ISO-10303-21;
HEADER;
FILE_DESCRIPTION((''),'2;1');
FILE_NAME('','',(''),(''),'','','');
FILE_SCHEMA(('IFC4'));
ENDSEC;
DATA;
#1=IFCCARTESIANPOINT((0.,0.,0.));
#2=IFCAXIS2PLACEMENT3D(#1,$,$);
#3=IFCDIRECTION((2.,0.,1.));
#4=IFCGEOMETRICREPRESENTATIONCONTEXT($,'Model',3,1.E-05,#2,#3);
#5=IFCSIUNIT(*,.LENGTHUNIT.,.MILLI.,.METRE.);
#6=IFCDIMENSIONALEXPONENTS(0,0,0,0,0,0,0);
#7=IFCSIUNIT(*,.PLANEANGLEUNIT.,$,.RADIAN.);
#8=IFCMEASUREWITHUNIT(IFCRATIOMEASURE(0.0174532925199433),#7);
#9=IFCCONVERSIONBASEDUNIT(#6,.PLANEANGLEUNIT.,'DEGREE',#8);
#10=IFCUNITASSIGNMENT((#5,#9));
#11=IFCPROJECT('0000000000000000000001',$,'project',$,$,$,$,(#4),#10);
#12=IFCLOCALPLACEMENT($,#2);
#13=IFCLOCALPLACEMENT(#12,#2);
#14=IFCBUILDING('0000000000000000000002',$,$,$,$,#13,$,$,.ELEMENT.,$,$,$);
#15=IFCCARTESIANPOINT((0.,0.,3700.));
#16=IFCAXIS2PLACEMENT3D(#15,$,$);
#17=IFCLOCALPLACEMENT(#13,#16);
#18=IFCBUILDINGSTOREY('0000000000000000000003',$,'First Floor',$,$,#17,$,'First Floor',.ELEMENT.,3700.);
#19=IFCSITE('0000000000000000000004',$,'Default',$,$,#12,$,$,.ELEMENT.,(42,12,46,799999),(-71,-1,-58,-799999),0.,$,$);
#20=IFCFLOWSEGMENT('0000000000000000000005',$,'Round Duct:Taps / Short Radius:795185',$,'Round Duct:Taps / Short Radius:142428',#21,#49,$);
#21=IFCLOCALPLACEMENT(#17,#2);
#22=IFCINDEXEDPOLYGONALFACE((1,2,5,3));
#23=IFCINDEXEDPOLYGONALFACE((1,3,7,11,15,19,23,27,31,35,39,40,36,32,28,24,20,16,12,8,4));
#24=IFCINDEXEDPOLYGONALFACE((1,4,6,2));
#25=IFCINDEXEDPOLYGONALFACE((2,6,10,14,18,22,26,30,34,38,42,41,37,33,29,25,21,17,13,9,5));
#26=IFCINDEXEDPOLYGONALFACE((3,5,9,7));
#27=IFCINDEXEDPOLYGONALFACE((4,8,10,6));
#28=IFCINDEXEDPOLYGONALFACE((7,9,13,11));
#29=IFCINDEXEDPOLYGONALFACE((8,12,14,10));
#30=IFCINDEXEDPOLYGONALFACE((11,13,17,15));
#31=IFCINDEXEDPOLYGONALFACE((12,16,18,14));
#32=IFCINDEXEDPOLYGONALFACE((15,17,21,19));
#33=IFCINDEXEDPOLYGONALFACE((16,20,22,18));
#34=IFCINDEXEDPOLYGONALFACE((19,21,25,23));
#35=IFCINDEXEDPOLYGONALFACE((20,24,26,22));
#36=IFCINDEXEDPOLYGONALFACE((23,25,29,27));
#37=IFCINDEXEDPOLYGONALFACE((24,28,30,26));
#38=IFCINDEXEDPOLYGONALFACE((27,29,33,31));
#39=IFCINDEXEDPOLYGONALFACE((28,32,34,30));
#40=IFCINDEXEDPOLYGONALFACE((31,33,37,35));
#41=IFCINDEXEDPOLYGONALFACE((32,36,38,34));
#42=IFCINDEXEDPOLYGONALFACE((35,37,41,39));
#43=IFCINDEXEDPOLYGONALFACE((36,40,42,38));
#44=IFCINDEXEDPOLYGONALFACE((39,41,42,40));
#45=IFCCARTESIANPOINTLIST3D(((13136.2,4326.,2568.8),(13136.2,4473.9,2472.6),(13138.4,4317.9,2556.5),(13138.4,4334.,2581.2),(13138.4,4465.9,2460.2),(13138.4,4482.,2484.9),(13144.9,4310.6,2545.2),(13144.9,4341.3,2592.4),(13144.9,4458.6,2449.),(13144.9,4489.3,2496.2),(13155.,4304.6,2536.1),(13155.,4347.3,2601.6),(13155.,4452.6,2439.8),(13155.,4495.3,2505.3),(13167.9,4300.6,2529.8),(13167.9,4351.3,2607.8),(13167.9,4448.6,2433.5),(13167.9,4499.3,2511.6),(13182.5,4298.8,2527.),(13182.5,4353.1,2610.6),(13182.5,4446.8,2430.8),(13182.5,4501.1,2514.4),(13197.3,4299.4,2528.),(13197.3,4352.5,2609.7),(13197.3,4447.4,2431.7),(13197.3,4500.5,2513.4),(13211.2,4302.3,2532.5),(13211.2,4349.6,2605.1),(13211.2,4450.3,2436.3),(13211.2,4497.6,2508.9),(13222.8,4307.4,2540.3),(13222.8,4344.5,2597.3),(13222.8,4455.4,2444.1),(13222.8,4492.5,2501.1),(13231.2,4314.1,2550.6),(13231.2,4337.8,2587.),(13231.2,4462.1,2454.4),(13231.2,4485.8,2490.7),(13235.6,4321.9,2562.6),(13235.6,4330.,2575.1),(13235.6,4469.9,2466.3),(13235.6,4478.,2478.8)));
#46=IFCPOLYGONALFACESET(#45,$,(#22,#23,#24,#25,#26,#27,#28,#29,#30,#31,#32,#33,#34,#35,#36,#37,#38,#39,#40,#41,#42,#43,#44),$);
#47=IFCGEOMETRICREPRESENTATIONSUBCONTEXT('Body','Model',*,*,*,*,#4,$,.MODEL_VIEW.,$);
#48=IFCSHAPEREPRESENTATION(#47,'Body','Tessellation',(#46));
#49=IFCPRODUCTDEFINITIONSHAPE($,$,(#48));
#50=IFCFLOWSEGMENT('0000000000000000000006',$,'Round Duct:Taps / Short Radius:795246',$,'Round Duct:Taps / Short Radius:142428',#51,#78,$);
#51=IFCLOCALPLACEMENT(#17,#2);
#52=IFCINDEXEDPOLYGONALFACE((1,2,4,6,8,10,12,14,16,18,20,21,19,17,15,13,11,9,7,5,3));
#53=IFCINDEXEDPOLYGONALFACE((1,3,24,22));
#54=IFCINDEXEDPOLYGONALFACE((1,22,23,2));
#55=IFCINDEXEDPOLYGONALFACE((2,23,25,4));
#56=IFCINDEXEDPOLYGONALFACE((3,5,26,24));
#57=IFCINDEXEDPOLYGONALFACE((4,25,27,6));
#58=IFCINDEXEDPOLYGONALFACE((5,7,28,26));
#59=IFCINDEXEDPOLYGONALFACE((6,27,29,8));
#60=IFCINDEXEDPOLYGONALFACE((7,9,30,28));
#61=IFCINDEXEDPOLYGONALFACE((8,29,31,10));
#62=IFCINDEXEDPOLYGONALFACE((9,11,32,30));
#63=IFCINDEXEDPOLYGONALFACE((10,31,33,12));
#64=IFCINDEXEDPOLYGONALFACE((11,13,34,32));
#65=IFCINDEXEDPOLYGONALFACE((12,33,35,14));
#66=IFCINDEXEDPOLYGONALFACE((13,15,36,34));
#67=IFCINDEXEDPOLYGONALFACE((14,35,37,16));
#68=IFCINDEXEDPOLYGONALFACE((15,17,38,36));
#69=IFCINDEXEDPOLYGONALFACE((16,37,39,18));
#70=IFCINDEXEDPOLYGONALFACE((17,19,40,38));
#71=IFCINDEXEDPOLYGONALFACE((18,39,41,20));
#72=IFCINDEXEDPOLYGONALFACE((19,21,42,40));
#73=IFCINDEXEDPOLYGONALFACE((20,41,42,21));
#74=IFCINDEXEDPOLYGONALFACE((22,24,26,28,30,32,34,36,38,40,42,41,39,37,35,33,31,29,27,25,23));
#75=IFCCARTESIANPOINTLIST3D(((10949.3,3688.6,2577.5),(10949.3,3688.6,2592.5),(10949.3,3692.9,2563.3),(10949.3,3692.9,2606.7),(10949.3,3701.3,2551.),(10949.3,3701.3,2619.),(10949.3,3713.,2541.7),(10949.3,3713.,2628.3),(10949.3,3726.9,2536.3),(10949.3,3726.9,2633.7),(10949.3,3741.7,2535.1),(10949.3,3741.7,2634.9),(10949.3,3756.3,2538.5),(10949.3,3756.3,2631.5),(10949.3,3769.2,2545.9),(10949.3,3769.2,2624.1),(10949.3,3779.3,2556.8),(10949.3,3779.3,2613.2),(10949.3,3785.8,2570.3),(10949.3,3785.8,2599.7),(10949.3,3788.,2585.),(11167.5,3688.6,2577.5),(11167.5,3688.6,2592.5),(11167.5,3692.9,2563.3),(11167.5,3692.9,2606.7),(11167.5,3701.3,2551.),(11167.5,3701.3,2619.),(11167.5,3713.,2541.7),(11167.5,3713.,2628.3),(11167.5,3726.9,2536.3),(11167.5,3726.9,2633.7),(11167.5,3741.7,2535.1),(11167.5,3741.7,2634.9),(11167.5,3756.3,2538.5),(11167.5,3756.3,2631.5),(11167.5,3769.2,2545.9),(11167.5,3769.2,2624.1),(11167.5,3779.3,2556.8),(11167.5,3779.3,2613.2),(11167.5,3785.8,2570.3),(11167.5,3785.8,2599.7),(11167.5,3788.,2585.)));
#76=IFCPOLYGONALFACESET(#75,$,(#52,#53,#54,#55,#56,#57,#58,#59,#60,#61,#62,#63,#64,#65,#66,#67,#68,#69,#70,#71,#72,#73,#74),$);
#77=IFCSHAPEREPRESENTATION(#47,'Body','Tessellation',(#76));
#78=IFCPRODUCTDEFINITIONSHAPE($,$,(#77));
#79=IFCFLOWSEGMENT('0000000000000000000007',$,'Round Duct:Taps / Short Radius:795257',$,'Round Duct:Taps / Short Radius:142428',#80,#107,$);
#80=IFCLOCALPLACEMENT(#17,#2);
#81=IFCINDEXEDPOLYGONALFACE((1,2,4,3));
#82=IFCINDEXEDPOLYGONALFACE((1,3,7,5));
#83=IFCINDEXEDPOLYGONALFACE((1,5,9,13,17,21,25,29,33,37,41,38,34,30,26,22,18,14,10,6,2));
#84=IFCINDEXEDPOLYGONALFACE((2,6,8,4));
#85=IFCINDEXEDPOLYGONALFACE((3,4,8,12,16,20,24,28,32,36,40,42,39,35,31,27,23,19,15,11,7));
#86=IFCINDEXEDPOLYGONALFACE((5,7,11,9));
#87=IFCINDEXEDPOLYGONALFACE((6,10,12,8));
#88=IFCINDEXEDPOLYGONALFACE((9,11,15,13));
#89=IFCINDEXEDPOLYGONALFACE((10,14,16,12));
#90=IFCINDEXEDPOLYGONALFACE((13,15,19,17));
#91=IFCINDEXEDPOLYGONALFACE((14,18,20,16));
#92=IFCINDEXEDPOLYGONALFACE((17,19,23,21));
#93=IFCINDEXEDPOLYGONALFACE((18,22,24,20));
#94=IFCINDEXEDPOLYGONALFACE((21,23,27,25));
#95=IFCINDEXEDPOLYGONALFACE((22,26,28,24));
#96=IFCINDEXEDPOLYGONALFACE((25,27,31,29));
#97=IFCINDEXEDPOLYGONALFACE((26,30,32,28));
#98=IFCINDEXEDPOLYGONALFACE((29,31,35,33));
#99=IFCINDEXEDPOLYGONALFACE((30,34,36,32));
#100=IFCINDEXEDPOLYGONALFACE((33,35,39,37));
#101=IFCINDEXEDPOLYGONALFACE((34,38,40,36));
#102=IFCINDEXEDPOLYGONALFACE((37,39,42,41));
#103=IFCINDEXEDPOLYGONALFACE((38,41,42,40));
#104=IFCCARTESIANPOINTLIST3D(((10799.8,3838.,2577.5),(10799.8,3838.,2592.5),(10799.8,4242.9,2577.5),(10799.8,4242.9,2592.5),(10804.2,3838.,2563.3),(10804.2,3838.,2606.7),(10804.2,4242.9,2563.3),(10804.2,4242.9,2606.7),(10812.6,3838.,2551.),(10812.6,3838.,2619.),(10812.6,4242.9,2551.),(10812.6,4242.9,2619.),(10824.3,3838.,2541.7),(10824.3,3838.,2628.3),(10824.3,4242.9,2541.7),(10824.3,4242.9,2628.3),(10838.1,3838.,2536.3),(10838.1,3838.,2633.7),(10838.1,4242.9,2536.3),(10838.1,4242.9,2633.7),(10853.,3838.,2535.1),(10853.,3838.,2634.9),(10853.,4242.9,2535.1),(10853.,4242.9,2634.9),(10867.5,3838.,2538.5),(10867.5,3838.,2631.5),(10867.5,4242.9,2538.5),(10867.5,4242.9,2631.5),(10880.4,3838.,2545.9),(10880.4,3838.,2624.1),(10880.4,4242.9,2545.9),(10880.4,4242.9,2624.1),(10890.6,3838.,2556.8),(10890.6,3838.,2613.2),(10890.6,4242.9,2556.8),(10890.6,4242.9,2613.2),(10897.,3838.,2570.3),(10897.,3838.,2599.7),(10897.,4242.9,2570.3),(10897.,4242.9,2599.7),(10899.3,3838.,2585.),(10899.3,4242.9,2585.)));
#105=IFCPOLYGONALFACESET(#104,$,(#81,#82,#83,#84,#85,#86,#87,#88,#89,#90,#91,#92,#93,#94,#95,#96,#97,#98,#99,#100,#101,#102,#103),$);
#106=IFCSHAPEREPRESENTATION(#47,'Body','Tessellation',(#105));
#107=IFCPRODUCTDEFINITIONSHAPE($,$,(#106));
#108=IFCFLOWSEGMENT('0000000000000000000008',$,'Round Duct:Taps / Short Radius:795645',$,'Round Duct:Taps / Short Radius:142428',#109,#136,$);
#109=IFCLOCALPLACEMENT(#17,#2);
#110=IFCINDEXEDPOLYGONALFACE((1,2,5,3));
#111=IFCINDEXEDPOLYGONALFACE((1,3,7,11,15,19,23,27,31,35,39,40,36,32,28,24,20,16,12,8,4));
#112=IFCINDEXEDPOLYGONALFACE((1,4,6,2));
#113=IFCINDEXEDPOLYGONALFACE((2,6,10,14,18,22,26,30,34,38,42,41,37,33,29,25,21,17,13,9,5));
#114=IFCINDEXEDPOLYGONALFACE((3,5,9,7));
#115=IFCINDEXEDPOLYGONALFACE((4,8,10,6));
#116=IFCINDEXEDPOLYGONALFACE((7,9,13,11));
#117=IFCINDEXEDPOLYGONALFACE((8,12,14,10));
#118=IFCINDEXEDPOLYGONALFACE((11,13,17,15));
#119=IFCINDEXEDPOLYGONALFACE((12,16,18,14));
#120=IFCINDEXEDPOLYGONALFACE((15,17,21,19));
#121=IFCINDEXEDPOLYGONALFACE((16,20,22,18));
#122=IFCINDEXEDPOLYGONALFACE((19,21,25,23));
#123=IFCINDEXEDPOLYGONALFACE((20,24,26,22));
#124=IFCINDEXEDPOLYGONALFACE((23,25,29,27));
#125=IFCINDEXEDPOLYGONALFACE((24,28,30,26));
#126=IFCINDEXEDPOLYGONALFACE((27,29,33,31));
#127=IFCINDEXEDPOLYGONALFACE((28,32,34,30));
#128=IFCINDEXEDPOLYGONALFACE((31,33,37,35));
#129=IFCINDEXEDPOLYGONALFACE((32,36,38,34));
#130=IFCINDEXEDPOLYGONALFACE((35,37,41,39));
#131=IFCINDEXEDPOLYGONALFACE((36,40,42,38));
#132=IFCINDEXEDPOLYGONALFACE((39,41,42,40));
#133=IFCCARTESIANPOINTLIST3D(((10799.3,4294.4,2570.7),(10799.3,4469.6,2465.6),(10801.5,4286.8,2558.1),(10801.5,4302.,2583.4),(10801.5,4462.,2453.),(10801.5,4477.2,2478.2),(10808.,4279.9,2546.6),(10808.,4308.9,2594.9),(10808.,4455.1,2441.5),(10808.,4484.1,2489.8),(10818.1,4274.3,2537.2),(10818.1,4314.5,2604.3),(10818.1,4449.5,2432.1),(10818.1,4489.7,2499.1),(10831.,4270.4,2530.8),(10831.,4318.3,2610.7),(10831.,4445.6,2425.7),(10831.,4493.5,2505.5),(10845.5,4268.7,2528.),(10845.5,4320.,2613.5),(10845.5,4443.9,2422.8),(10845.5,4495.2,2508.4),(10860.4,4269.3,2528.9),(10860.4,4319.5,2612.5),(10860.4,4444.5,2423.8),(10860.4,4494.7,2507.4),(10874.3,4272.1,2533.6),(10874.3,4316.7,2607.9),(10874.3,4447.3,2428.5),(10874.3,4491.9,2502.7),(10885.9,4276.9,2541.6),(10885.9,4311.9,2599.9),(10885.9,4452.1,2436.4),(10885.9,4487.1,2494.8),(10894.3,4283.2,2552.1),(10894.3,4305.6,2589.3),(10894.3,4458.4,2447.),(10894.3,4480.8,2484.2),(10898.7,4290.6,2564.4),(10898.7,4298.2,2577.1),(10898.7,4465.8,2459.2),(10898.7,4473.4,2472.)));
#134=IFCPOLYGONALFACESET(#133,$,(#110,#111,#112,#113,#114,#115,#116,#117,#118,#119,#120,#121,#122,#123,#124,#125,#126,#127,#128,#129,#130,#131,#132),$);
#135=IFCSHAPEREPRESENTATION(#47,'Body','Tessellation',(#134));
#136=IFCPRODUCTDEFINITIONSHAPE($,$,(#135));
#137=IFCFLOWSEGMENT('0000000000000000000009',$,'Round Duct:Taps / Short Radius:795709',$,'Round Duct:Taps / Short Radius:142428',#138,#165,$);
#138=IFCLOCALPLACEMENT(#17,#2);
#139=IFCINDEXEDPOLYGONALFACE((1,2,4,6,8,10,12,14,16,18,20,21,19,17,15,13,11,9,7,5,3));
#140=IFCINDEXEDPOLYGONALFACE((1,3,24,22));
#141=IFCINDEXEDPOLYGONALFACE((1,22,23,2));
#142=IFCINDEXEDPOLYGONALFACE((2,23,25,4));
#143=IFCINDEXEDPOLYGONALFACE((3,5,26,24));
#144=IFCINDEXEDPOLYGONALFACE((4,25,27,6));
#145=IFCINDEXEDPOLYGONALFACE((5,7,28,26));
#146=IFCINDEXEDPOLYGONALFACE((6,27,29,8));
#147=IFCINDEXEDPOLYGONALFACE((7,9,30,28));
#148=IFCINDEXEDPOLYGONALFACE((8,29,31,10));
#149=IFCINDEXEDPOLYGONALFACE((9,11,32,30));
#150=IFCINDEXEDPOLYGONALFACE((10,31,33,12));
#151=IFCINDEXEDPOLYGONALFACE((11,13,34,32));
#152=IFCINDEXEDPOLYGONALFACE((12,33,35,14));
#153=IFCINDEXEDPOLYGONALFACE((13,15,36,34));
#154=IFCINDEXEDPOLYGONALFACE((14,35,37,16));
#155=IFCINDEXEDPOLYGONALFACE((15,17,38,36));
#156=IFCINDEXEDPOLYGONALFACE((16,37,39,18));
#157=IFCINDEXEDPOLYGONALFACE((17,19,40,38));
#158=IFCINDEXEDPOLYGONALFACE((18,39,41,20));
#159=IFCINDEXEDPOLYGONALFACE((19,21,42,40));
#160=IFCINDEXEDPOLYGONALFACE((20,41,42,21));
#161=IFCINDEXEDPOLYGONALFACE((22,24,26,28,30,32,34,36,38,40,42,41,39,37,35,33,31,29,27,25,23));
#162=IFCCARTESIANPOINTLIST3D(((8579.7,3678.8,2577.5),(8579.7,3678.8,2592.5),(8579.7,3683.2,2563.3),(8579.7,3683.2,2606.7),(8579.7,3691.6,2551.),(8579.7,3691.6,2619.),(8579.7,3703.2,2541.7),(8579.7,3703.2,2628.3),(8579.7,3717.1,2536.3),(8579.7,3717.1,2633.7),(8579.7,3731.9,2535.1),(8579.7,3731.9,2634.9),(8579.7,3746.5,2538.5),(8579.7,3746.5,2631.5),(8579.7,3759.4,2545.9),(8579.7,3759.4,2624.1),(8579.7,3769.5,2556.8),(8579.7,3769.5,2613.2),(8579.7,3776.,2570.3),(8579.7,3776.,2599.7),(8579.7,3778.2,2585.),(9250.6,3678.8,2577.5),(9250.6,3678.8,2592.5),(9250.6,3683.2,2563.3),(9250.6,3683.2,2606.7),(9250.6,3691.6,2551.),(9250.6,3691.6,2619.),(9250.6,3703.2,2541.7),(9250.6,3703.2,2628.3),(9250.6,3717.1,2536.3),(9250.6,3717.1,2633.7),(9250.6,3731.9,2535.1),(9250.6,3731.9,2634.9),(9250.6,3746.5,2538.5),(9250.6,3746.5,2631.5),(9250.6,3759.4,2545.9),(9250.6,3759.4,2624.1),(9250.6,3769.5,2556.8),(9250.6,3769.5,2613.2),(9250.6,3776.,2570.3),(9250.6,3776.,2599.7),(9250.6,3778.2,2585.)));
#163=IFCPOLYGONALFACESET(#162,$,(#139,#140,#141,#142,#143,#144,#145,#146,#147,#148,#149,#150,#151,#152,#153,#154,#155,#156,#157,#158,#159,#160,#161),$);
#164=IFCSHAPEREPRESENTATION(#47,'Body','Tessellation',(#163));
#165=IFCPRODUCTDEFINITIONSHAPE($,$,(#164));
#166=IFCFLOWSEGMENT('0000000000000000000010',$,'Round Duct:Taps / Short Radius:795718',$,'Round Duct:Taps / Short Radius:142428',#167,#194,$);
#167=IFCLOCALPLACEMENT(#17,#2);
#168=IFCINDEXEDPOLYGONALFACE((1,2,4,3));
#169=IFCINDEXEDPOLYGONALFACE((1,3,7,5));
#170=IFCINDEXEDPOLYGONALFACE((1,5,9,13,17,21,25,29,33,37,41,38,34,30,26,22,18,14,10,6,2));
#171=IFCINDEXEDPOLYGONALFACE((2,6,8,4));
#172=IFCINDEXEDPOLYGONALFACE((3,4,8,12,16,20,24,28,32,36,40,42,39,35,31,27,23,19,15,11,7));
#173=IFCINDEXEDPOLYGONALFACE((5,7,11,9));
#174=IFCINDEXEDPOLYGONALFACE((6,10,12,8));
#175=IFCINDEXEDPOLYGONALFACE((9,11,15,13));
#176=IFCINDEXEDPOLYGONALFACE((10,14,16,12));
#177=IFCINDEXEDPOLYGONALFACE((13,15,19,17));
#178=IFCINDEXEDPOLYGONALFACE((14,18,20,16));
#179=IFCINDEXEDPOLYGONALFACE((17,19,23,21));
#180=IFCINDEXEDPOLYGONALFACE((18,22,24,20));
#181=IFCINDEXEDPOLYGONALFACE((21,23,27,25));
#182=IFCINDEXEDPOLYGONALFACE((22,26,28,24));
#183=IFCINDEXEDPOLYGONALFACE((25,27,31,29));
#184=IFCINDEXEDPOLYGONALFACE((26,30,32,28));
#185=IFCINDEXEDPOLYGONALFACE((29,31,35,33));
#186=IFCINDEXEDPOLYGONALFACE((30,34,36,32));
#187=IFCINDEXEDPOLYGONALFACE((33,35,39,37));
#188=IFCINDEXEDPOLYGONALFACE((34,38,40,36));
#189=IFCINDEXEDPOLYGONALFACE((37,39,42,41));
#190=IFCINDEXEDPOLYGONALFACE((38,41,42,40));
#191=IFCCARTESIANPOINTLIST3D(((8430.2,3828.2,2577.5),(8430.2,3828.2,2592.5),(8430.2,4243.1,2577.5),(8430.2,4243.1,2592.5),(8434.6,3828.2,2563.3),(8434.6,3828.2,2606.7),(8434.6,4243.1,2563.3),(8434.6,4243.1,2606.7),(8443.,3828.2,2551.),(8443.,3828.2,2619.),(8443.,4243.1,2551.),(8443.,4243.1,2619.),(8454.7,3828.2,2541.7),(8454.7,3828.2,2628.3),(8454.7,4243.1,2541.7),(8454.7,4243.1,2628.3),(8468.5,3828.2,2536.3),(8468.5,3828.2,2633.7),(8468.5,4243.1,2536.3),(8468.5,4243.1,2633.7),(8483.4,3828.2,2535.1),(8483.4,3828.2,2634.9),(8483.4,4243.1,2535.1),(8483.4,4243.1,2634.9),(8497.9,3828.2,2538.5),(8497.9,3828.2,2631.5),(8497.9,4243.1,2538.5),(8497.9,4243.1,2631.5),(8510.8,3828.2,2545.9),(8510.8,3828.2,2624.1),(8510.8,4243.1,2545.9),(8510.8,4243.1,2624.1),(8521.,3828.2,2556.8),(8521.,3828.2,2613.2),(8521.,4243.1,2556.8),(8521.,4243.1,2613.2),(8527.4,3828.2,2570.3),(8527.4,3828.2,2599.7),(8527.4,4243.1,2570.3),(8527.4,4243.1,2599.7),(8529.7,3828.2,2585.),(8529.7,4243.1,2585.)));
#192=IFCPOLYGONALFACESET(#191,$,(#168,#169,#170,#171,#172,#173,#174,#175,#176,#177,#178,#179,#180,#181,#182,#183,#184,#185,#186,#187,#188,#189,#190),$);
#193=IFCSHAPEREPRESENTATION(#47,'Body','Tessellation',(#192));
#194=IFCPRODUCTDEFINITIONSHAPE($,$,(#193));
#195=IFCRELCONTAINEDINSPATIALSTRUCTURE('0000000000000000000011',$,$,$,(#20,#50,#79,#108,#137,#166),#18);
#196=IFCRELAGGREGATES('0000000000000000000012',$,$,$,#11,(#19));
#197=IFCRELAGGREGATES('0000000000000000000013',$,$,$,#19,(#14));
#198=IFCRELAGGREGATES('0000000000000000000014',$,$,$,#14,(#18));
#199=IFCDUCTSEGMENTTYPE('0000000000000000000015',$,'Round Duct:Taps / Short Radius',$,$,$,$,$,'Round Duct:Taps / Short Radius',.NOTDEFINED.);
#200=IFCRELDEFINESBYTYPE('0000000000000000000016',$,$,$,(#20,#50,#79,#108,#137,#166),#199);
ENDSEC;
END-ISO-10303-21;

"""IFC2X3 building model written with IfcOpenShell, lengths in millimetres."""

from ifc_helpers import new_model, entity, si_unit, converted_unit, direction, frame, frame_2d, origin, origin_2d_with_axis, place, context, subcontext, project, spatial, circle, extrude, type_object, element, save


model = new_model("IFC2X3")

# Units and contexts
model_context = context("Model", 3, precision=1e-05, world=origin(), true_north=direction((2.0, 0.0, 1.0)))
body_context = subcontext(model_context, "Body", "Model", "MODEL_VIEW")
ifc_project = project(units=[si_unit("LENGTHUNIT", "METRE", prefix="MILLI"), converted_unit("PLANEANGLEUNIT", "DEGREE", entity("IfcRatioMeasure", 0.0174532925199433), si_unit("PLANEANGLEUNIT", "RADIAN"), dimensions=[0, 0, 0, 0, 0, 0, 0])], contexts=[model_context])

# Site, building, storey
site_placement = place(None, origin())
site = spatial("IfcSite", under=ifc_project, at=site_placement, Name="Default", CompositionType="ELEMENT", RefLatitude=(42, 12, 46, 799999), RefLongitude=(-71, -1, -58, -799999), RefElevation=0.0)
building_placement = place(site_placement, origin())
building = spatial("IfcBuilding", under=site, at=building_placement, CompositionType="ELEMENT")
storey_placement = place(building_placement, frame((0.0, 0.0, 3700.0)))
storey = spatial("IfcBuildingStorey", under=building, at=storey_placement, Name="First Floor", LongName="First Floor", CompositionType="ELEMENT", Elevation=3700.0)

# Flow segments
duct_segment_type_1 = type_object("IfcDuctSegmentType", Name="Round Duct:Taps / Short Radius", ElementType="Round Duct:Taps / Short Radius", PredefinedType="NOTDEFINED")
flow_segment_1_placement = place(storey_placement, origin())
element("IfcFlowSegment", 1, at=flow_segment_1_placement, inside=storey, type_object=duct_segment_type_1, Name="Round Duct:Taps / Short Radius:795185", ObjectType="Round Duct:Taps / Short Radius:142428", context=body_context, shape_type="SweptSolid", body=[
    extrude(circle(Radius=50.0, at=frame_2d((0.0, 0.0), x_axis=(1.0, 0.0))), frame((13186.2, 4326.0, 2568.8), z_axis=(0.0, 0.83825, -0.545286), x_axis=(-1.0, 0.0, 0.0)), (0.0, 0.0, 1.0), 176.5),
])
flow_segment_2_placement = place(storey_placement, origin())
element("IfcFlowSegment", 2, at=flow_segment_2_placement, inside=storey, type_object=duct_segment_type_1, Name="Round Duct:Taps / Short Radius:795246", ObjectType="Round Duct:Taps / Short Radius:142428", context=body_context, shape_type="SweptSolid", body=[
    extrude(circle(Radius=50.0, at=origin_2d_with_axis()), frame((10949.3, 3738.0, 2585.0), z_axis=(1.0, 0.0, 0.0), x_axis=(0.0, 1.0, 0.0)), (0.0, 0.0, 1.0), 218.3),
])
flow_segment_3_placement = place(storey_placement, origin())
element("IfcFlowSegment", 3, at=flow_segment_3_placement, inside=storey, type_object=duct_segment_type_1, Name="Round Duct:Taps / Short Radius:795257", ObjectType="Round Duct:Taps / Short Radius:142428", context=body_context, shape_type="SweptSolid", body=[
    extrude(circle(Radius=50.0, at=origin_2d_with_axis()), frame((10849.3, 3838.0, 2585.0), z_axis=(0.0, 1.0, 0.0), x_axis=(1.0, 0.0, 0.0)), (0.0, 0.0, 1.0), 404.9),
])
flow_segment_4_placement = place(storey_placement, origin())
element("IfcFlowSegment", 4, at=flow_segment_4_placement, inside=storey, type_object=duct_segment_type_1, Name="Round Duct:Taps / Short Radius:795645", ObjectType="Round Duct:Taps / Short Radius:142428", context=body_context, shape_type="SweptSolid", body=[
    extrude(circle(Radius=50.0, at=frame_2d((0.0, 0.0), x_axis=(1.0, 0.0))), frame((10849.3, 4294.4, 2570.7), z_axis=(0.0, 0.857448, -0.51457), x_axis=(-1.0, 0.0, 0.0)), (0.0, 0.0, 1.0), 204.3),
])
flow_segment_5_placement = place(storey_placement, origin())
element("IfcFlowSegment", 5, at=flow_segment_5_placement, inside=storey, type_object=duct_segment_type_1, Name="Round Duct:Taps / Short Radius:795709", ObjectType="Round Duct:Taps / Short Radius:142428", context=body_context, shape_type="SweptSolid", body=[
    extrude(circle(Radius=50.0, at=frame_2d((0.0, 0.0), x_axis=(1.0, 0.0))), frame((8579.7, 3728.2, 2585.0), z_axis=(1.0, 0.0, 0.0), x_axis=(0.0, 1.0, 0.0)), (0.0, 0.0, 1.0), 670.9),
])
flow_segment_6_placement = place(storey_placement, origin())
element("IfcFlowSegment", 6, at=flow_segment_6_placement, inside=storey, type_object=duct_segment_type_1, Name="Round Duct:Taps / Short Radius:795718", ObjectType="Round Duct:Taps / Short Radius:142428", context=body_context, shape_type="SweptSolid", body=[
    extrude(circle(Radius=50.0, at=origin_2d_with_axis()), frame((8479.7, 3828.2, 2585.0), z_axis=(0.0, 1.0, 0.0), x_axis=(1.0, 0.0, 0.0)), (0.0, 0.0, 1.0), 414.9),
])

save(model, "model.ifc")
